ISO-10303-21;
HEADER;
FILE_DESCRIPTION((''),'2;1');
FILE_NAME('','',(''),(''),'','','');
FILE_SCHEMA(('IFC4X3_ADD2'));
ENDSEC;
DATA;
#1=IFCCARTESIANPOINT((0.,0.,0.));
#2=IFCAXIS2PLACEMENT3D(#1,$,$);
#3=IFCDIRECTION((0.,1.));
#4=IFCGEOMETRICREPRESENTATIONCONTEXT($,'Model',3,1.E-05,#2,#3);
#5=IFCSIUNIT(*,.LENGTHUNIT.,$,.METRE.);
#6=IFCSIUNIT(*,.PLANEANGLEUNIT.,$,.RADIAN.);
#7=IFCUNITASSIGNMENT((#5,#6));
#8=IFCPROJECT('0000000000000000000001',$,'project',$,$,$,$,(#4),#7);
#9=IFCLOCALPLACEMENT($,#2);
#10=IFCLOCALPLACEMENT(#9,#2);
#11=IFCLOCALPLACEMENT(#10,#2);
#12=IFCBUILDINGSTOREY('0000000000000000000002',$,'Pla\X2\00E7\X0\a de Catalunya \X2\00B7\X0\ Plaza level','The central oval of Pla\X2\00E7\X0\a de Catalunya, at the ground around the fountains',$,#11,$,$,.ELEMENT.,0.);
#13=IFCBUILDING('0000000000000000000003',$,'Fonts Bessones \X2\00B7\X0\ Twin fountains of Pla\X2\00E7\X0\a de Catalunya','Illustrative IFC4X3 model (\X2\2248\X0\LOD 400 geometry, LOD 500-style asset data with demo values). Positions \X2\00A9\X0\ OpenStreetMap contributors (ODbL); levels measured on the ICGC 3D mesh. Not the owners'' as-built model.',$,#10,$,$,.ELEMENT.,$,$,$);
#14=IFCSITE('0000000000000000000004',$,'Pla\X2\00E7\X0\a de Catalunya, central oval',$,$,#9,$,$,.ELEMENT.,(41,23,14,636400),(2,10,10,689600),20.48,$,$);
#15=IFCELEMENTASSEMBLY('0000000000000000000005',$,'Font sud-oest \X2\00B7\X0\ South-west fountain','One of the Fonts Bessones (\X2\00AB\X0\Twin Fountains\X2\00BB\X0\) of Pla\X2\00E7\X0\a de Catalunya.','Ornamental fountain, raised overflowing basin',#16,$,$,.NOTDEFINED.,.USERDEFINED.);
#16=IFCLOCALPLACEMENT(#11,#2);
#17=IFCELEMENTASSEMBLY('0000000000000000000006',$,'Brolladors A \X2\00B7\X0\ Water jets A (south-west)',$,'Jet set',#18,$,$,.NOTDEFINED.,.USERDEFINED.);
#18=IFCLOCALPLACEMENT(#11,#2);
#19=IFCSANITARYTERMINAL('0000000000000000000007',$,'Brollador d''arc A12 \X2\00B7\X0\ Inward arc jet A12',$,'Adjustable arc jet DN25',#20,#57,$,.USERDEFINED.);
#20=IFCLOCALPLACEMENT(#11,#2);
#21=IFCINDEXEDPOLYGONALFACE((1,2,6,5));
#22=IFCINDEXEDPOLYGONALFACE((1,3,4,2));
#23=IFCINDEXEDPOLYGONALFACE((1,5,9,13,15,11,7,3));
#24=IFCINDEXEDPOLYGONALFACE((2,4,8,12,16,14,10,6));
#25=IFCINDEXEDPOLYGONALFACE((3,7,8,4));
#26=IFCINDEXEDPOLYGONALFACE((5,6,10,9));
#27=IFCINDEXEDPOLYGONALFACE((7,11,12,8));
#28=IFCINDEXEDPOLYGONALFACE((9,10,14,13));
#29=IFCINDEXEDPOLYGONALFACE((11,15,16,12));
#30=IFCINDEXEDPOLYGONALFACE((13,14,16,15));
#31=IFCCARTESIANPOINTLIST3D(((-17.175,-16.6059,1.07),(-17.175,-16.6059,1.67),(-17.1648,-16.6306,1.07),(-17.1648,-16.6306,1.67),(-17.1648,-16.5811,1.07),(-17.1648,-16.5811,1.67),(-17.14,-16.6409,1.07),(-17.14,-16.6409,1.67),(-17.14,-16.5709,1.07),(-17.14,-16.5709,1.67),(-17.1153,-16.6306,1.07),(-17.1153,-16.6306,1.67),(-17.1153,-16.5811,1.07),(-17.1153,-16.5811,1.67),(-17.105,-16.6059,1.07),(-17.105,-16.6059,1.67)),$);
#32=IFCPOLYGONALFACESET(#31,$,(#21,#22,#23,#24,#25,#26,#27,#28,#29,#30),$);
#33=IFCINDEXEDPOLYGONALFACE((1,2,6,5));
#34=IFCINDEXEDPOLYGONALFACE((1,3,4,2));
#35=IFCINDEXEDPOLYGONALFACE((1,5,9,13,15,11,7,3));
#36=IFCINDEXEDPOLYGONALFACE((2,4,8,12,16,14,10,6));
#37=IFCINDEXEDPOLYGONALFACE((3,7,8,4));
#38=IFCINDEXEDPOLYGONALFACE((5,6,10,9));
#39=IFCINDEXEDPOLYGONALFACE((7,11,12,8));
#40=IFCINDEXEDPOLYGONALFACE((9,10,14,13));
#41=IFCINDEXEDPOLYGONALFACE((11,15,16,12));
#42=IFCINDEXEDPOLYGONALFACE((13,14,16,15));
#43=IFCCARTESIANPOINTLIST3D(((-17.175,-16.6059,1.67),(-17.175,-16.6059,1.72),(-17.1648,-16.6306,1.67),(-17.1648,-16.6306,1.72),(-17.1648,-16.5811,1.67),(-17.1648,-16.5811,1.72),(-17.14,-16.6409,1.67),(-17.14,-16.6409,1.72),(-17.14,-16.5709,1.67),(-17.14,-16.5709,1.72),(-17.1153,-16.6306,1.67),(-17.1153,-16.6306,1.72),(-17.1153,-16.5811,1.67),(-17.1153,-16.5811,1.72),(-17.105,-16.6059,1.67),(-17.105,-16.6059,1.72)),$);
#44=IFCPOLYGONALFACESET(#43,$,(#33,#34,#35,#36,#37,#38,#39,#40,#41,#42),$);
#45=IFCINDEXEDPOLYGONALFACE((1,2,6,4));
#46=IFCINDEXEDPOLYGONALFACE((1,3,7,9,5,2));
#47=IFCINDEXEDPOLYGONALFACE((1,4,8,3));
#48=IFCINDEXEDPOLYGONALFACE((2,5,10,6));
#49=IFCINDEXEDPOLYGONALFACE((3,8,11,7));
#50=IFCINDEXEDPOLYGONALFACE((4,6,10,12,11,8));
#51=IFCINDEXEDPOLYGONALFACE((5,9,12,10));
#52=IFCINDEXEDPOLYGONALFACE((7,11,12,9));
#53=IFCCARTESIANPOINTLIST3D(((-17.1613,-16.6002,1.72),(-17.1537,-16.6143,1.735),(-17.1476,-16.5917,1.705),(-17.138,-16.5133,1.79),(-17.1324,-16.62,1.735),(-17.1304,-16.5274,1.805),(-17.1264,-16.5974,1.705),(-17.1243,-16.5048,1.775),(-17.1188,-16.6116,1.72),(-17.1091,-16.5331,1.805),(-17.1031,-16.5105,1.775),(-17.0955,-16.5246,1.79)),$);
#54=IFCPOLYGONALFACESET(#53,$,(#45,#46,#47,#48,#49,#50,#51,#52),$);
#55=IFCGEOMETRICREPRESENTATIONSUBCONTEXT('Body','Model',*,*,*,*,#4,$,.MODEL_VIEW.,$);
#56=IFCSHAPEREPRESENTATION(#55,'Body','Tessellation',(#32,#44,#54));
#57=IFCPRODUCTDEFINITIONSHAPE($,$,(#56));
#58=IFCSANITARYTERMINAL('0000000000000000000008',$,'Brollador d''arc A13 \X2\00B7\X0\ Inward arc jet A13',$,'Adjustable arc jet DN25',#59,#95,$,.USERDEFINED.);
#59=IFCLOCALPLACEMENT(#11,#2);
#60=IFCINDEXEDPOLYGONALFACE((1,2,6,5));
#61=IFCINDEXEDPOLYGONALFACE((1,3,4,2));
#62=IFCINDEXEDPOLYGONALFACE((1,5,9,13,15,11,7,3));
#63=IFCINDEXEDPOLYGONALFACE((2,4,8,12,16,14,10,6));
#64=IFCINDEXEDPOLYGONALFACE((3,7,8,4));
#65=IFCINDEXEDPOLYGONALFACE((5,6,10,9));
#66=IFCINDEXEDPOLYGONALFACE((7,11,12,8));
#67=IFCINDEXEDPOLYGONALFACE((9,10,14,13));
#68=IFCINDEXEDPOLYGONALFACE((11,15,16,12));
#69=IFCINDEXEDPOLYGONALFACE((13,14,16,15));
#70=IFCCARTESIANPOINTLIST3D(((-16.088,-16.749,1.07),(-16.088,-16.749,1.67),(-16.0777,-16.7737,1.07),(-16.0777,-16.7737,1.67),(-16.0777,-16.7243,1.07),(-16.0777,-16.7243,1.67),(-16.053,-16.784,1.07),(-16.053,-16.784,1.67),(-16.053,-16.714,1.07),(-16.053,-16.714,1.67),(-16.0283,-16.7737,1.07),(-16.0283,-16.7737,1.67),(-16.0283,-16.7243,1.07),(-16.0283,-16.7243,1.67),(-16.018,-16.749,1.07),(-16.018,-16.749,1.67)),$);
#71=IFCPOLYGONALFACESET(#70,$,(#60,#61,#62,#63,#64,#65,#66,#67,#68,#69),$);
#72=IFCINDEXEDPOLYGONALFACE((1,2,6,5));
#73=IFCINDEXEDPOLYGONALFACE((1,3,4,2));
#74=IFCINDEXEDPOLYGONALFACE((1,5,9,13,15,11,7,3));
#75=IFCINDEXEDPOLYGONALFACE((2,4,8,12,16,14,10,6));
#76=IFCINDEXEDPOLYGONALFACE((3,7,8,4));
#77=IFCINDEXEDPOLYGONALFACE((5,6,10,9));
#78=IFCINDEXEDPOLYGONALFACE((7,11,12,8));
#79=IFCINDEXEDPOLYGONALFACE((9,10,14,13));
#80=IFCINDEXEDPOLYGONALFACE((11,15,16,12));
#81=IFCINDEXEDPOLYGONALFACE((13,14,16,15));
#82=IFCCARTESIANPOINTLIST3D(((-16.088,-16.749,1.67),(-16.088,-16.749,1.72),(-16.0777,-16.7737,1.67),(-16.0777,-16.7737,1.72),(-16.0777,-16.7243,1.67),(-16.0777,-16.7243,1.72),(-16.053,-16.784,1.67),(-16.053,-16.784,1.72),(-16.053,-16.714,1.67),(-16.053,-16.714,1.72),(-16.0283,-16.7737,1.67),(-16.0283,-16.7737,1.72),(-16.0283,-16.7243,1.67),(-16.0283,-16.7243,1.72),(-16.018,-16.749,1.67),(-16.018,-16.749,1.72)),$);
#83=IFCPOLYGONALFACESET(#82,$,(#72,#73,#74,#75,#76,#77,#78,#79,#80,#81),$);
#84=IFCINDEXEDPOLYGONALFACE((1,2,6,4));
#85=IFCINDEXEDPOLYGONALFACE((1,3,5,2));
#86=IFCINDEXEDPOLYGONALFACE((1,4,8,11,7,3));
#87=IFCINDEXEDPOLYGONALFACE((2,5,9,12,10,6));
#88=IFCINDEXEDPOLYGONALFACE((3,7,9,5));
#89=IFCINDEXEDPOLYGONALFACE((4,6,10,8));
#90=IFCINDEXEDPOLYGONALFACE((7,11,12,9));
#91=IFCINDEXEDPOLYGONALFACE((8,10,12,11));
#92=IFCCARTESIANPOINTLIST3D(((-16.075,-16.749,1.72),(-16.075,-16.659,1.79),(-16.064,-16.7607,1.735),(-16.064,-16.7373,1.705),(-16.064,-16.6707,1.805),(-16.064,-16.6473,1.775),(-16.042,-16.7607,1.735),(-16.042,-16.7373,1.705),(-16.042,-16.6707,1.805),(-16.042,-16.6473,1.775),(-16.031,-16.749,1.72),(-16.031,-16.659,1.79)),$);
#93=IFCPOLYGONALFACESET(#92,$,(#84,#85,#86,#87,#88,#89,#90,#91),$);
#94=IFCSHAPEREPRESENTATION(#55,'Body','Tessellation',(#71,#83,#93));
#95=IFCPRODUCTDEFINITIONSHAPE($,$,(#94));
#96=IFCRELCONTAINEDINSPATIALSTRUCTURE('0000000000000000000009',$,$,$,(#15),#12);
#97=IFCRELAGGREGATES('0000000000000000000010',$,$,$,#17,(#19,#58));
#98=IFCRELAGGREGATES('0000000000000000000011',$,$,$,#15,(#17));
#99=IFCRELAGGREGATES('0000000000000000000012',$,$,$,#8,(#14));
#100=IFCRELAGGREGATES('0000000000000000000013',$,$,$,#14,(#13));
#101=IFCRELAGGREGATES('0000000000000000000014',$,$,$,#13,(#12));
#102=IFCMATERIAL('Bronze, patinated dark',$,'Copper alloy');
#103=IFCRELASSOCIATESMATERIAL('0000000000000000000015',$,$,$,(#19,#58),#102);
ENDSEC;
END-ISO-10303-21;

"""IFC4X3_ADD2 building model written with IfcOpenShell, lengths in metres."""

from ifc_helpers import new_model, si_unit, direction, frame, origin, place, context, subcontext, project, spatial, polyline, outline, extrude, material, element, aggregate, save


model = new_model("IFC4X3_ADD2")

# Units and contexts
model_context = context("Model", 3, precision=1e-05, world=origin(), true_north=direction((0.0, 1.0)))
body_context = subcontext(model_context, "Body", "Model", "MODEL_VIEW")
ifc_project = project(units=[si_unit("LENGTHUNIT", "METRE"), si_unit("PLANEANGLEUNIT", "RADIAN")], contexts=[model_context])

# Site, building, storey
site_placement = place(None, origin())
site = spatial("IfcSite", under=ifc_project, at=site_placement, Name="Plaça de Catalunya, central oval", CompositionType="ELEMENT", RefLatitude=(41, 23, 14, 636400), RefLongitude=(2, 10, 10, 689600), RefElevation=20.48)
building_placement = place(site_placement, origin())
building = spatial("IfcBuilding", under=site, at=building_placement, Name="Fonts Bessones · Twin fountains of Plaça de Catalunya", Description="Illustrative IFC4X3 model (≈LOD 400 geometry, LOD 500-style asset data with demo values). Positions © OpenStreetMap contributors (ODbL); levels measured on the ICGC 3D mesh. Not the owners' as-built model.", CompositionType="ELEMENT")
storey_placement = place(building_placement, origin())
storey = spatial("IfcBuildingStorey", under=building, at=storey_placement, Name="Plaça de Catalunya · Plaza level", Description="The central oval of Plaça de Catalunya, at the ground around the fountains", CompositionType="ELEMENT", Elevation=0.0)

# Element assemblies, sanitary terminals
assembly_1_placement = place(building_placement, origin())
assembly_1 = element("IfcElementAssembly", 1, at=assembly_1_placement, inside=storey, Name="Font sud-oest · South-west fountain", Description="One of the Fonts Bessones («Twin Fountains») of Plaça de Catalunya.", ObjectType="Ornamental fountain, raised overflowing basin", AssemblyPlace="NOTDEFINED", PredefinedType="USERDEFINED")
assembly_2_placement = place(building_placement, origin())
assembly_2 = element("IfcElementAssembly", 2, at=assembly_2_placement, Name="Brolladors A · Water jets A (south-west)", ObjectType="Jet set", AssemblyPlace="NOTDEFINED", PredefinedType="USERDEFINED")
ifc_material_1 = material(Name="Bronze, patinated dark", Category="Copper alloy")
sanitary_terminal_1_placement = place(building_placement, origin())
sanitary_terminal_1 = element("IfcSanitaryTerminal", 3, at=sanitary_terminal_1_placement, material=ifc_material_1, Name="Brollador d'arc A12 · Inward arc jet A12", ObjectType="Adjustable arc jet DN25", PredefinedType="USERDEFINED", context=body_context, shape_type="SweptSolid", body=[
    extrude(outline(polyline([(-17.105, -16.6059), (-17.1153, -16.5811), (-17.14, -16.5709), (-17.1648, -16.5811), (-17.175, -16.6059), (-17.1648, -16.6306), (-17.14, -16.6409), (-17.1153, -16.6306), (-17.105, -16.6059)])), frame((0.0, 0.0, 1.07)), (0.0, 0.0, 1.0), 0.6),
    extrude(outline(polyline([(-17.105, -16.6059), (-17.1153, -16.5811), (-17.14, -16.5709), (-17.1648, -16.5811), (-17.175, -16.6059), (-17.1648, -16.6306), (-17.14, -16.6409), (-17.1153, -16.6306), (-17.105, -16.6059)])), frame((0.0, 0.0, 1.67)), (0.0, 0.0, 1.0), 0.05),
    extrude(outline(polyline([(0.022, 0.0), (0.011, 0.0191), (-0.011, 0.0191), (-0.022, 0.0), (-0.011, -0.0191), (0.011, -0.0191), (0.022, 0.0)])), frame((-17.14, -16.6059, 1.72), z_axis=(0.204299, 0.762456, 0.613941), x_axis=(0.965926, -0.258819, 0.0)), (0.0, 0.0, 1.0), 0.114),
])
sanitary_terminal_2_placement = place(building_placement, origin())
sanitary_terminal_2 = element("IfcSanitaryTerminal", 4, at=sanitary_terminal_2_placement, material=ifc_material_1, Name="Brollador d'arc A13 · Inward arc jet A13", ObjectType="Adjustable arc jet DN25", PredefinedType="USERDEFINED", context=body_context, shape_type="SweptSolid", body=[
    extrude(outline(polyline([(-16.018, -16.749), (-16.0283, -16.7243), (-16.053, -16.714), (-16.0777, -16.7243), (-16.088, -16.749), (-16.0777, -16.7737), (-16.053, -16.784), (-16.0283, -16.7737), (-16.018, -16.749)])), frame((0.0, 0.0, 1.07)), (0.0, 0.0, 1.0), 0.6),
    extrude(outline(polyline([(-16.018, -16.749), (-16.0283, -16.7243), (-16.053, -16.714), (-16.0777, -16.7243), (-16.088, -16.749), (-16.0777, -16.7737), (-16.053, -16.784), (-16.0283, -16.7737), (-16.018, -16.749)])), frame((0.0, 0.0, 1.67)), (0.0, 0.0, 1.0), 0.05),
    extrude(outline(polyline([(0.022, 0.0), (0.011, 0.0191), (-0.011, 0.0191), (-0.022, 0.0), (-0.011, -0.0191), (0.011, -0.0191), (0.022, 0.0)])), frame((-16.053, -16.749, 1.72), z_axis=(0.0, 0.789352, 0.613941), x_axis=(1.0, 0.0, 0.0)), (0.0, 0.0, 1.0), 0.114),
])
aggregate(assembly_2, [sanitary_terminal_1, sanitary_terminal_2])
aggregate(assembly_1, [assembly_2])

save(model, "model.ifc")
